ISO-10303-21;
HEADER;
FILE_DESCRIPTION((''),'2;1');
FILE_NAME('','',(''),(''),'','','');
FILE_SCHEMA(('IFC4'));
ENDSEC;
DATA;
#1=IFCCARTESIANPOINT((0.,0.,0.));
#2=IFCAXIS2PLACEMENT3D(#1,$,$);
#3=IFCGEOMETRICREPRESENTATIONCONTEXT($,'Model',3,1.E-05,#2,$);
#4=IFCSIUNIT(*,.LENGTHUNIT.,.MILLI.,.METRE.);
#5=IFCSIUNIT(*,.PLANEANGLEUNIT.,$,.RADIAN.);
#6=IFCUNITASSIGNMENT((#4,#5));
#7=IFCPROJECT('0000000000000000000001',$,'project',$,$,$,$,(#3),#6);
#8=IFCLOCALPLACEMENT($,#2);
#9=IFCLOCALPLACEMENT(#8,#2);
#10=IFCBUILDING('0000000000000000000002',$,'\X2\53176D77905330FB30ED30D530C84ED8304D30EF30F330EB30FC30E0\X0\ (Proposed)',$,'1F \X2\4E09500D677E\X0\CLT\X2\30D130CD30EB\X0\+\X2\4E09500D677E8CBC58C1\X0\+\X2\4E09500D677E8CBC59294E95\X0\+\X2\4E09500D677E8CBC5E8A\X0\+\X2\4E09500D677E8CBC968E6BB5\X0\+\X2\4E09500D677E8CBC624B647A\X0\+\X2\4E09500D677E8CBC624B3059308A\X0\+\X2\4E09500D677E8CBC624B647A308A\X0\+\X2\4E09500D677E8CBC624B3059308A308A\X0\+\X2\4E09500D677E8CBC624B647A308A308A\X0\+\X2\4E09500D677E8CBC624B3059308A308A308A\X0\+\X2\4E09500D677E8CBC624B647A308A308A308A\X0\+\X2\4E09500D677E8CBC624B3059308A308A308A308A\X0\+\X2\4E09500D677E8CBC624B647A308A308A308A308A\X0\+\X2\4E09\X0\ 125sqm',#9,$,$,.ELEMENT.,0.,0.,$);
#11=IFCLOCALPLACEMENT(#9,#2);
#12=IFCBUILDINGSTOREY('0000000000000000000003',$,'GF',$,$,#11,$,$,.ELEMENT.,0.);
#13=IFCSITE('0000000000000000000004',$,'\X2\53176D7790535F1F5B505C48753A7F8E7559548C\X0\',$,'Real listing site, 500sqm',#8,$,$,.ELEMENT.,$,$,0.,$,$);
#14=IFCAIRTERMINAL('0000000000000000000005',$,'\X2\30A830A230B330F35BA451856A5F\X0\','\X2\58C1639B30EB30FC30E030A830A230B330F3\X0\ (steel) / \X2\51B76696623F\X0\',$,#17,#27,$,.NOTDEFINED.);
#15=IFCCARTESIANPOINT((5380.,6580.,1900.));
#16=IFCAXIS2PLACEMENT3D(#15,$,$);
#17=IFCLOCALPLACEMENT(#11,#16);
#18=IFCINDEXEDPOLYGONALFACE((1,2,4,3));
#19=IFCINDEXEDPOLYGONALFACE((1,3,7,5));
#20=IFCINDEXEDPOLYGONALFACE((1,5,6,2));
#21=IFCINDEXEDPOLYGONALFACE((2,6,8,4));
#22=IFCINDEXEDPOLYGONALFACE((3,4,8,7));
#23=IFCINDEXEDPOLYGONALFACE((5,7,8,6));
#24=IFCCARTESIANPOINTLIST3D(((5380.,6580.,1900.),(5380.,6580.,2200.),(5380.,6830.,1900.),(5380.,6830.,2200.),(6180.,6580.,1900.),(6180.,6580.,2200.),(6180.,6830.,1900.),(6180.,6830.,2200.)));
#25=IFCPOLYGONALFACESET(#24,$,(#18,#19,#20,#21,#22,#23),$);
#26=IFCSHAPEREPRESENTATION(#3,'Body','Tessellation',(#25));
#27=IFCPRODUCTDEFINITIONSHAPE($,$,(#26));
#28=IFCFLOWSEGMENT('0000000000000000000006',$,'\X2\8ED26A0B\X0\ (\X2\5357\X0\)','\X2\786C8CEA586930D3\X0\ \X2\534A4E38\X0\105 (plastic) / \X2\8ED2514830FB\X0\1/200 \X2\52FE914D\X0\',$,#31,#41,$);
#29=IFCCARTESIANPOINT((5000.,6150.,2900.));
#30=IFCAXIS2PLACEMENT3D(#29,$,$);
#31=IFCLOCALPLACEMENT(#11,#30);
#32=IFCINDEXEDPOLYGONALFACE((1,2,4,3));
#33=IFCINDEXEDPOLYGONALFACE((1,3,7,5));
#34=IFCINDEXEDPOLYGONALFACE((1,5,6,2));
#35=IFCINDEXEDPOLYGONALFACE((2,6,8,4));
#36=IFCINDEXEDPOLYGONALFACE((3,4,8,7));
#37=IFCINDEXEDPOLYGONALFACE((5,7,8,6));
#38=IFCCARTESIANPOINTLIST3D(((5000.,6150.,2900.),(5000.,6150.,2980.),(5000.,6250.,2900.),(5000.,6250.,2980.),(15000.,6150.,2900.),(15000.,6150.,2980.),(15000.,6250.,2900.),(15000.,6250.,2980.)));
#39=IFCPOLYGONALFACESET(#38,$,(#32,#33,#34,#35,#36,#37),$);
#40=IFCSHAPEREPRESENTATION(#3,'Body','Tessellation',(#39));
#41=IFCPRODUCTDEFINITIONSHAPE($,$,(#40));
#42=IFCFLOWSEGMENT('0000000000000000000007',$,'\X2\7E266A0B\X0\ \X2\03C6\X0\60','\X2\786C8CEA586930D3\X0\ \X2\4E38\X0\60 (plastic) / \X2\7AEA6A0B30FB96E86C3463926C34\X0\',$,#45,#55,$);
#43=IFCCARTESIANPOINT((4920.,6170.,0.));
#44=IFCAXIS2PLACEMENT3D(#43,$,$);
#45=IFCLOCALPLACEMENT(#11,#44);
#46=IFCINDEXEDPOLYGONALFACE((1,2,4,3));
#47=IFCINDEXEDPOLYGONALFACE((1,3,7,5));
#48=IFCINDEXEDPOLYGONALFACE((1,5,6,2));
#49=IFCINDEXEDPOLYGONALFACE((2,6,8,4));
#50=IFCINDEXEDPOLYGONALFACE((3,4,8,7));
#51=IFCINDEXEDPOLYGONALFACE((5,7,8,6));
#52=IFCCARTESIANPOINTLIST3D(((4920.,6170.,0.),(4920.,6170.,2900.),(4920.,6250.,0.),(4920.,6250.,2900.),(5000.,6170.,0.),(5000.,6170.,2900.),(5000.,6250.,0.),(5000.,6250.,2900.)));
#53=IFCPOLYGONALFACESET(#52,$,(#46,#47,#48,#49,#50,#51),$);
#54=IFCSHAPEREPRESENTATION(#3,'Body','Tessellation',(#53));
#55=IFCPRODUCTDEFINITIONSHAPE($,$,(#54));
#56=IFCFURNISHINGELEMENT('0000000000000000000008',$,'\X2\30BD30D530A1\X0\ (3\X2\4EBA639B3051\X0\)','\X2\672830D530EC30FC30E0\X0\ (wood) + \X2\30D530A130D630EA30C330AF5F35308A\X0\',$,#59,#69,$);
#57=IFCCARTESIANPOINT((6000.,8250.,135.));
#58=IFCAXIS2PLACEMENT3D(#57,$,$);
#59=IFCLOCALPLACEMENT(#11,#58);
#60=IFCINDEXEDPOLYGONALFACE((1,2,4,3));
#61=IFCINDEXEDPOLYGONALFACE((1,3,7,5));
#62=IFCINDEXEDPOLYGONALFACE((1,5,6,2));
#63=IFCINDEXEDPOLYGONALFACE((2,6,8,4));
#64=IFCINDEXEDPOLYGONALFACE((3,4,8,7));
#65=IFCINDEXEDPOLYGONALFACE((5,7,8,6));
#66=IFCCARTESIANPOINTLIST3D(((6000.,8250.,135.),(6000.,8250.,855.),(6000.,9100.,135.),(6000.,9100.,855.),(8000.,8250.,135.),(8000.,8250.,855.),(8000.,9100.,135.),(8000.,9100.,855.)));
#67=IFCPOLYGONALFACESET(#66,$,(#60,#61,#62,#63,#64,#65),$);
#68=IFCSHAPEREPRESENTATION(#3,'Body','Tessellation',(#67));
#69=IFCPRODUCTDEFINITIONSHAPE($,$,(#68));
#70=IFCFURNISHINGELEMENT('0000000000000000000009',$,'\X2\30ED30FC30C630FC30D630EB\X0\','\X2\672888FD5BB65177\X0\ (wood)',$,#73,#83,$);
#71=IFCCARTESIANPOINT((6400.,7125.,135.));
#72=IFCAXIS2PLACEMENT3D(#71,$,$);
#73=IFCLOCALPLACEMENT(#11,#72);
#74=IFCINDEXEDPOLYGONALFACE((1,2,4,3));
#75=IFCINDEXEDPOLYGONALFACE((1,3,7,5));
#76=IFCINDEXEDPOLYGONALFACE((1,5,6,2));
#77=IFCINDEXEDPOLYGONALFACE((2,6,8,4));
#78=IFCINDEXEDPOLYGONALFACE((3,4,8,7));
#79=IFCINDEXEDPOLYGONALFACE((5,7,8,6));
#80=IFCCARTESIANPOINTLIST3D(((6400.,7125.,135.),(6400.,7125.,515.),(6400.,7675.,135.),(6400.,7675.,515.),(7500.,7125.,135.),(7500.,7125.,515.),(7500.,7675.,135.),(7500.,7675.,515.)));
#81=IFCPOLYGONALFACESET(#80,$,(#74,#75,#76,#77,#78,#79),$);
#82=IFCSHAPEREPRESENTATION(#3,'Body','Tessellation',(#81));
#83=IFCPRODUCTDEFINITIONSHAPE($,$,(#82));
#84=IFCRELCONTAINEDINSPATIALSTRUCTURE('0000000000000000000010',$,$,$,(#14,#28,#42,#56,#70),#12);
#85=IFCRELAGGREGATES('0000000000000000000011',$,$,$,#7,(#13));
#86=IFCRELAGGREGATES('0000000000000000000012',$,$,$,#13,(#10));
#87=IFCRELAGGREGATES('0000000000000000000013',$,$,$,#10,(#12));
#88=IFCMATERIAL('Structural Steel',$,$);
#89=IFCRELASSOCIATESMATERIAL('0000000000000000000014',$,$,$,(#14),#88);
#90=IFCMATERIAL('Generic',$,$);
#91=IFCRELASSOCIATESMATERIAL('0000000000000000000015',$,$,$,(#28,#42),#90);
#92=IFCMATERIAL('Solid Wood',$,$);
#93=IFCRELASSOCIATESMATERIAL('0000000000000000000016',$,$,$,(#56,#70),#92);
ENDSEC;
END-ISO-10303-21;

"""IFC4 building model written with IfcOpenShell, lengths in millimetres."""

from ifc_helpers import new_model, si_unit, frame, frame_2d, origin, place, context, project, spatial, rectangle, extrude, material, element, save


model = new_model("IFC4")

# Units and contexts
model_context = context("Model", 3, precision=1e-05, world=origin())
ifc_project = project(units=[si_unit("LENGTHUNIT", "METRE", prefix="MILLI"), si_unit("PLANEANGLEUNIT", "RADIAN")], contexts=[model_context])

# Site, building, storey
site_placement = place(None, origin())
site = spatial("IfcSite", under=ifc_project, at=site_placement, Name="北海道弟子屈町美留和", ObjectType="Real listing site, 500sqm", CompositionType="ELEMENT", RefElevation=0.0)
building_placement = place(site_placement, origin())
building = spatial("IfcBuilding", under=site, at=building_placement, Name="北海道・ロフト付きワンルーム (Proposed)", ObjectType="1F 三倍松CLTパネル+三倍松貼壁+三倍松貼天井+三倍松貼床+三倍松貼階段+三倍松貼手摺+三倍松貼手すり+三倍松貼手摺り+三倍松貼手すりり+三倍松貼手摺りり+三倍松貼手すりりり+三倍松貼手摺りりり+三倍松貼手すりりりり+三倍松貼手摺りりりり+三 125sqm", CompositionType="ELEMENT", ElevationOfRefHeight=0.0, ElevationOfTerrain=0.0)
storey_placement = place(building_placement, origin())
storey = spatial("IfcBuildingStorey", under=building, at=storey_placement, Name="GF", CompositionType="ELEMENT", Elevation=0.0)

# Shared definitions
ifc_material_1 = material(Name="Solid Wood")

# Shared definitions
ifc_material_2 = material(Name="Structural Steel")

# Shared definitions
ifc_material_3 = material(Name="Generic")

# Air terminal
air_terminal_placement = place(storey_placement, frame((5380.0, 6580.0, 1900.0)))
element("IfcAirTerminal", 1, at=air_terminal_placement, inside=storey, material=ifc_material_2, Name="エアコン室内機", Description="壁掛ルームエアコン (steel) / 冷暖房", PredefinedType="NOTDEFINED", context=model_context, shape_type="SweptSolid", body=[
    extrude(rectangle(XDim=800.0, YDim=250.0, at=frame_2d((400.0, 125.0))), frame((5380.0, 6580.0, 1900.0)), (0.0, 0.0, 1.0), 300.0),
])

# Flow segments
flow_segment_1_placement = place(storey_placement, frame((5000.0, 6150.0, 2900.0)))
element("IfcFlowSegment", 2, at=flow_segment_1_placement, inside=storey, material=ifc_material_3, Name="軒樋 (南)", Description="硬質塩ビ 半丸105 (plastic) / 軒先・1/200 勾配", context=model_context, shape_type="SweptSolid", body=[
    extrude(rectangle(XDim=10000.0, YDim=100.0, at=frame_2d((5000.0, 50.0))), frame((5000.0, 6150.0, 2900.0)), (0.0, 0.0, 1.0), 80.0),
])
flow_segment_2_placement = place(storey_placement, frame((4920.0, 6170.0, 0.0)))
element("IfcFlowSegment", 3, at=flow_segment_2_placement, inside=storey, material=ifc_material_3, Name="縦樋 φ60", Description="硬質塩ビ 丸60 (plastic) / 竪樋・雨水排水", context=model_context, shape_type="SweptSolid", body=[
    extrude(rectangle(XDim=80.0, YDim=80.0, at=frame_2d((40.0, 40.0))), frame((4920.0, 6170.0, 0.0)), (0.0, 0.0, 1.0), 2900.0),
])

# Furnishing elements
furnishing_1_placement = place(storey_placement, frame((6000.0, 8250.0, 135.0)))
element("IfcFurnishingElement", 4, at=furnishing_1_placement, inside=storey, material=ifc_material_1, Name="ソファ (3人掛け)", Description="木フレーム (wood) + ファブリック張り", context=model_context, shape_type="SweptSolid", body=[
    extrude(rectangle(XDim=2000.0, YDim=850.0, at=frame_2d((1000.0, 425.0))), frame((6000.0, 8250.0, 135.0)), (0.0, 0.0, 1.0), 720.0),
])
furnishing_2_placement = place(storey_placement, frame((6400.0, 7125.0, 135.0)))
element("IfcFurnishingElement", 5, at=furnishing_2_placement, inside=storey, material=ifc_material_1, Name="ローテーブル", Description="木製家具 (wood)", context=model_context, shape_type="SweptSolid", body=[
    extrude(rectangle(XDim=1100.0, YDim=550.0, at=frame_2d((550.0, 275.0))), frame((6400.0, 7125.0, 135.0)), (0.0, 0.0, 1.0), 380.0),
])

save(model, "model.ifc")
